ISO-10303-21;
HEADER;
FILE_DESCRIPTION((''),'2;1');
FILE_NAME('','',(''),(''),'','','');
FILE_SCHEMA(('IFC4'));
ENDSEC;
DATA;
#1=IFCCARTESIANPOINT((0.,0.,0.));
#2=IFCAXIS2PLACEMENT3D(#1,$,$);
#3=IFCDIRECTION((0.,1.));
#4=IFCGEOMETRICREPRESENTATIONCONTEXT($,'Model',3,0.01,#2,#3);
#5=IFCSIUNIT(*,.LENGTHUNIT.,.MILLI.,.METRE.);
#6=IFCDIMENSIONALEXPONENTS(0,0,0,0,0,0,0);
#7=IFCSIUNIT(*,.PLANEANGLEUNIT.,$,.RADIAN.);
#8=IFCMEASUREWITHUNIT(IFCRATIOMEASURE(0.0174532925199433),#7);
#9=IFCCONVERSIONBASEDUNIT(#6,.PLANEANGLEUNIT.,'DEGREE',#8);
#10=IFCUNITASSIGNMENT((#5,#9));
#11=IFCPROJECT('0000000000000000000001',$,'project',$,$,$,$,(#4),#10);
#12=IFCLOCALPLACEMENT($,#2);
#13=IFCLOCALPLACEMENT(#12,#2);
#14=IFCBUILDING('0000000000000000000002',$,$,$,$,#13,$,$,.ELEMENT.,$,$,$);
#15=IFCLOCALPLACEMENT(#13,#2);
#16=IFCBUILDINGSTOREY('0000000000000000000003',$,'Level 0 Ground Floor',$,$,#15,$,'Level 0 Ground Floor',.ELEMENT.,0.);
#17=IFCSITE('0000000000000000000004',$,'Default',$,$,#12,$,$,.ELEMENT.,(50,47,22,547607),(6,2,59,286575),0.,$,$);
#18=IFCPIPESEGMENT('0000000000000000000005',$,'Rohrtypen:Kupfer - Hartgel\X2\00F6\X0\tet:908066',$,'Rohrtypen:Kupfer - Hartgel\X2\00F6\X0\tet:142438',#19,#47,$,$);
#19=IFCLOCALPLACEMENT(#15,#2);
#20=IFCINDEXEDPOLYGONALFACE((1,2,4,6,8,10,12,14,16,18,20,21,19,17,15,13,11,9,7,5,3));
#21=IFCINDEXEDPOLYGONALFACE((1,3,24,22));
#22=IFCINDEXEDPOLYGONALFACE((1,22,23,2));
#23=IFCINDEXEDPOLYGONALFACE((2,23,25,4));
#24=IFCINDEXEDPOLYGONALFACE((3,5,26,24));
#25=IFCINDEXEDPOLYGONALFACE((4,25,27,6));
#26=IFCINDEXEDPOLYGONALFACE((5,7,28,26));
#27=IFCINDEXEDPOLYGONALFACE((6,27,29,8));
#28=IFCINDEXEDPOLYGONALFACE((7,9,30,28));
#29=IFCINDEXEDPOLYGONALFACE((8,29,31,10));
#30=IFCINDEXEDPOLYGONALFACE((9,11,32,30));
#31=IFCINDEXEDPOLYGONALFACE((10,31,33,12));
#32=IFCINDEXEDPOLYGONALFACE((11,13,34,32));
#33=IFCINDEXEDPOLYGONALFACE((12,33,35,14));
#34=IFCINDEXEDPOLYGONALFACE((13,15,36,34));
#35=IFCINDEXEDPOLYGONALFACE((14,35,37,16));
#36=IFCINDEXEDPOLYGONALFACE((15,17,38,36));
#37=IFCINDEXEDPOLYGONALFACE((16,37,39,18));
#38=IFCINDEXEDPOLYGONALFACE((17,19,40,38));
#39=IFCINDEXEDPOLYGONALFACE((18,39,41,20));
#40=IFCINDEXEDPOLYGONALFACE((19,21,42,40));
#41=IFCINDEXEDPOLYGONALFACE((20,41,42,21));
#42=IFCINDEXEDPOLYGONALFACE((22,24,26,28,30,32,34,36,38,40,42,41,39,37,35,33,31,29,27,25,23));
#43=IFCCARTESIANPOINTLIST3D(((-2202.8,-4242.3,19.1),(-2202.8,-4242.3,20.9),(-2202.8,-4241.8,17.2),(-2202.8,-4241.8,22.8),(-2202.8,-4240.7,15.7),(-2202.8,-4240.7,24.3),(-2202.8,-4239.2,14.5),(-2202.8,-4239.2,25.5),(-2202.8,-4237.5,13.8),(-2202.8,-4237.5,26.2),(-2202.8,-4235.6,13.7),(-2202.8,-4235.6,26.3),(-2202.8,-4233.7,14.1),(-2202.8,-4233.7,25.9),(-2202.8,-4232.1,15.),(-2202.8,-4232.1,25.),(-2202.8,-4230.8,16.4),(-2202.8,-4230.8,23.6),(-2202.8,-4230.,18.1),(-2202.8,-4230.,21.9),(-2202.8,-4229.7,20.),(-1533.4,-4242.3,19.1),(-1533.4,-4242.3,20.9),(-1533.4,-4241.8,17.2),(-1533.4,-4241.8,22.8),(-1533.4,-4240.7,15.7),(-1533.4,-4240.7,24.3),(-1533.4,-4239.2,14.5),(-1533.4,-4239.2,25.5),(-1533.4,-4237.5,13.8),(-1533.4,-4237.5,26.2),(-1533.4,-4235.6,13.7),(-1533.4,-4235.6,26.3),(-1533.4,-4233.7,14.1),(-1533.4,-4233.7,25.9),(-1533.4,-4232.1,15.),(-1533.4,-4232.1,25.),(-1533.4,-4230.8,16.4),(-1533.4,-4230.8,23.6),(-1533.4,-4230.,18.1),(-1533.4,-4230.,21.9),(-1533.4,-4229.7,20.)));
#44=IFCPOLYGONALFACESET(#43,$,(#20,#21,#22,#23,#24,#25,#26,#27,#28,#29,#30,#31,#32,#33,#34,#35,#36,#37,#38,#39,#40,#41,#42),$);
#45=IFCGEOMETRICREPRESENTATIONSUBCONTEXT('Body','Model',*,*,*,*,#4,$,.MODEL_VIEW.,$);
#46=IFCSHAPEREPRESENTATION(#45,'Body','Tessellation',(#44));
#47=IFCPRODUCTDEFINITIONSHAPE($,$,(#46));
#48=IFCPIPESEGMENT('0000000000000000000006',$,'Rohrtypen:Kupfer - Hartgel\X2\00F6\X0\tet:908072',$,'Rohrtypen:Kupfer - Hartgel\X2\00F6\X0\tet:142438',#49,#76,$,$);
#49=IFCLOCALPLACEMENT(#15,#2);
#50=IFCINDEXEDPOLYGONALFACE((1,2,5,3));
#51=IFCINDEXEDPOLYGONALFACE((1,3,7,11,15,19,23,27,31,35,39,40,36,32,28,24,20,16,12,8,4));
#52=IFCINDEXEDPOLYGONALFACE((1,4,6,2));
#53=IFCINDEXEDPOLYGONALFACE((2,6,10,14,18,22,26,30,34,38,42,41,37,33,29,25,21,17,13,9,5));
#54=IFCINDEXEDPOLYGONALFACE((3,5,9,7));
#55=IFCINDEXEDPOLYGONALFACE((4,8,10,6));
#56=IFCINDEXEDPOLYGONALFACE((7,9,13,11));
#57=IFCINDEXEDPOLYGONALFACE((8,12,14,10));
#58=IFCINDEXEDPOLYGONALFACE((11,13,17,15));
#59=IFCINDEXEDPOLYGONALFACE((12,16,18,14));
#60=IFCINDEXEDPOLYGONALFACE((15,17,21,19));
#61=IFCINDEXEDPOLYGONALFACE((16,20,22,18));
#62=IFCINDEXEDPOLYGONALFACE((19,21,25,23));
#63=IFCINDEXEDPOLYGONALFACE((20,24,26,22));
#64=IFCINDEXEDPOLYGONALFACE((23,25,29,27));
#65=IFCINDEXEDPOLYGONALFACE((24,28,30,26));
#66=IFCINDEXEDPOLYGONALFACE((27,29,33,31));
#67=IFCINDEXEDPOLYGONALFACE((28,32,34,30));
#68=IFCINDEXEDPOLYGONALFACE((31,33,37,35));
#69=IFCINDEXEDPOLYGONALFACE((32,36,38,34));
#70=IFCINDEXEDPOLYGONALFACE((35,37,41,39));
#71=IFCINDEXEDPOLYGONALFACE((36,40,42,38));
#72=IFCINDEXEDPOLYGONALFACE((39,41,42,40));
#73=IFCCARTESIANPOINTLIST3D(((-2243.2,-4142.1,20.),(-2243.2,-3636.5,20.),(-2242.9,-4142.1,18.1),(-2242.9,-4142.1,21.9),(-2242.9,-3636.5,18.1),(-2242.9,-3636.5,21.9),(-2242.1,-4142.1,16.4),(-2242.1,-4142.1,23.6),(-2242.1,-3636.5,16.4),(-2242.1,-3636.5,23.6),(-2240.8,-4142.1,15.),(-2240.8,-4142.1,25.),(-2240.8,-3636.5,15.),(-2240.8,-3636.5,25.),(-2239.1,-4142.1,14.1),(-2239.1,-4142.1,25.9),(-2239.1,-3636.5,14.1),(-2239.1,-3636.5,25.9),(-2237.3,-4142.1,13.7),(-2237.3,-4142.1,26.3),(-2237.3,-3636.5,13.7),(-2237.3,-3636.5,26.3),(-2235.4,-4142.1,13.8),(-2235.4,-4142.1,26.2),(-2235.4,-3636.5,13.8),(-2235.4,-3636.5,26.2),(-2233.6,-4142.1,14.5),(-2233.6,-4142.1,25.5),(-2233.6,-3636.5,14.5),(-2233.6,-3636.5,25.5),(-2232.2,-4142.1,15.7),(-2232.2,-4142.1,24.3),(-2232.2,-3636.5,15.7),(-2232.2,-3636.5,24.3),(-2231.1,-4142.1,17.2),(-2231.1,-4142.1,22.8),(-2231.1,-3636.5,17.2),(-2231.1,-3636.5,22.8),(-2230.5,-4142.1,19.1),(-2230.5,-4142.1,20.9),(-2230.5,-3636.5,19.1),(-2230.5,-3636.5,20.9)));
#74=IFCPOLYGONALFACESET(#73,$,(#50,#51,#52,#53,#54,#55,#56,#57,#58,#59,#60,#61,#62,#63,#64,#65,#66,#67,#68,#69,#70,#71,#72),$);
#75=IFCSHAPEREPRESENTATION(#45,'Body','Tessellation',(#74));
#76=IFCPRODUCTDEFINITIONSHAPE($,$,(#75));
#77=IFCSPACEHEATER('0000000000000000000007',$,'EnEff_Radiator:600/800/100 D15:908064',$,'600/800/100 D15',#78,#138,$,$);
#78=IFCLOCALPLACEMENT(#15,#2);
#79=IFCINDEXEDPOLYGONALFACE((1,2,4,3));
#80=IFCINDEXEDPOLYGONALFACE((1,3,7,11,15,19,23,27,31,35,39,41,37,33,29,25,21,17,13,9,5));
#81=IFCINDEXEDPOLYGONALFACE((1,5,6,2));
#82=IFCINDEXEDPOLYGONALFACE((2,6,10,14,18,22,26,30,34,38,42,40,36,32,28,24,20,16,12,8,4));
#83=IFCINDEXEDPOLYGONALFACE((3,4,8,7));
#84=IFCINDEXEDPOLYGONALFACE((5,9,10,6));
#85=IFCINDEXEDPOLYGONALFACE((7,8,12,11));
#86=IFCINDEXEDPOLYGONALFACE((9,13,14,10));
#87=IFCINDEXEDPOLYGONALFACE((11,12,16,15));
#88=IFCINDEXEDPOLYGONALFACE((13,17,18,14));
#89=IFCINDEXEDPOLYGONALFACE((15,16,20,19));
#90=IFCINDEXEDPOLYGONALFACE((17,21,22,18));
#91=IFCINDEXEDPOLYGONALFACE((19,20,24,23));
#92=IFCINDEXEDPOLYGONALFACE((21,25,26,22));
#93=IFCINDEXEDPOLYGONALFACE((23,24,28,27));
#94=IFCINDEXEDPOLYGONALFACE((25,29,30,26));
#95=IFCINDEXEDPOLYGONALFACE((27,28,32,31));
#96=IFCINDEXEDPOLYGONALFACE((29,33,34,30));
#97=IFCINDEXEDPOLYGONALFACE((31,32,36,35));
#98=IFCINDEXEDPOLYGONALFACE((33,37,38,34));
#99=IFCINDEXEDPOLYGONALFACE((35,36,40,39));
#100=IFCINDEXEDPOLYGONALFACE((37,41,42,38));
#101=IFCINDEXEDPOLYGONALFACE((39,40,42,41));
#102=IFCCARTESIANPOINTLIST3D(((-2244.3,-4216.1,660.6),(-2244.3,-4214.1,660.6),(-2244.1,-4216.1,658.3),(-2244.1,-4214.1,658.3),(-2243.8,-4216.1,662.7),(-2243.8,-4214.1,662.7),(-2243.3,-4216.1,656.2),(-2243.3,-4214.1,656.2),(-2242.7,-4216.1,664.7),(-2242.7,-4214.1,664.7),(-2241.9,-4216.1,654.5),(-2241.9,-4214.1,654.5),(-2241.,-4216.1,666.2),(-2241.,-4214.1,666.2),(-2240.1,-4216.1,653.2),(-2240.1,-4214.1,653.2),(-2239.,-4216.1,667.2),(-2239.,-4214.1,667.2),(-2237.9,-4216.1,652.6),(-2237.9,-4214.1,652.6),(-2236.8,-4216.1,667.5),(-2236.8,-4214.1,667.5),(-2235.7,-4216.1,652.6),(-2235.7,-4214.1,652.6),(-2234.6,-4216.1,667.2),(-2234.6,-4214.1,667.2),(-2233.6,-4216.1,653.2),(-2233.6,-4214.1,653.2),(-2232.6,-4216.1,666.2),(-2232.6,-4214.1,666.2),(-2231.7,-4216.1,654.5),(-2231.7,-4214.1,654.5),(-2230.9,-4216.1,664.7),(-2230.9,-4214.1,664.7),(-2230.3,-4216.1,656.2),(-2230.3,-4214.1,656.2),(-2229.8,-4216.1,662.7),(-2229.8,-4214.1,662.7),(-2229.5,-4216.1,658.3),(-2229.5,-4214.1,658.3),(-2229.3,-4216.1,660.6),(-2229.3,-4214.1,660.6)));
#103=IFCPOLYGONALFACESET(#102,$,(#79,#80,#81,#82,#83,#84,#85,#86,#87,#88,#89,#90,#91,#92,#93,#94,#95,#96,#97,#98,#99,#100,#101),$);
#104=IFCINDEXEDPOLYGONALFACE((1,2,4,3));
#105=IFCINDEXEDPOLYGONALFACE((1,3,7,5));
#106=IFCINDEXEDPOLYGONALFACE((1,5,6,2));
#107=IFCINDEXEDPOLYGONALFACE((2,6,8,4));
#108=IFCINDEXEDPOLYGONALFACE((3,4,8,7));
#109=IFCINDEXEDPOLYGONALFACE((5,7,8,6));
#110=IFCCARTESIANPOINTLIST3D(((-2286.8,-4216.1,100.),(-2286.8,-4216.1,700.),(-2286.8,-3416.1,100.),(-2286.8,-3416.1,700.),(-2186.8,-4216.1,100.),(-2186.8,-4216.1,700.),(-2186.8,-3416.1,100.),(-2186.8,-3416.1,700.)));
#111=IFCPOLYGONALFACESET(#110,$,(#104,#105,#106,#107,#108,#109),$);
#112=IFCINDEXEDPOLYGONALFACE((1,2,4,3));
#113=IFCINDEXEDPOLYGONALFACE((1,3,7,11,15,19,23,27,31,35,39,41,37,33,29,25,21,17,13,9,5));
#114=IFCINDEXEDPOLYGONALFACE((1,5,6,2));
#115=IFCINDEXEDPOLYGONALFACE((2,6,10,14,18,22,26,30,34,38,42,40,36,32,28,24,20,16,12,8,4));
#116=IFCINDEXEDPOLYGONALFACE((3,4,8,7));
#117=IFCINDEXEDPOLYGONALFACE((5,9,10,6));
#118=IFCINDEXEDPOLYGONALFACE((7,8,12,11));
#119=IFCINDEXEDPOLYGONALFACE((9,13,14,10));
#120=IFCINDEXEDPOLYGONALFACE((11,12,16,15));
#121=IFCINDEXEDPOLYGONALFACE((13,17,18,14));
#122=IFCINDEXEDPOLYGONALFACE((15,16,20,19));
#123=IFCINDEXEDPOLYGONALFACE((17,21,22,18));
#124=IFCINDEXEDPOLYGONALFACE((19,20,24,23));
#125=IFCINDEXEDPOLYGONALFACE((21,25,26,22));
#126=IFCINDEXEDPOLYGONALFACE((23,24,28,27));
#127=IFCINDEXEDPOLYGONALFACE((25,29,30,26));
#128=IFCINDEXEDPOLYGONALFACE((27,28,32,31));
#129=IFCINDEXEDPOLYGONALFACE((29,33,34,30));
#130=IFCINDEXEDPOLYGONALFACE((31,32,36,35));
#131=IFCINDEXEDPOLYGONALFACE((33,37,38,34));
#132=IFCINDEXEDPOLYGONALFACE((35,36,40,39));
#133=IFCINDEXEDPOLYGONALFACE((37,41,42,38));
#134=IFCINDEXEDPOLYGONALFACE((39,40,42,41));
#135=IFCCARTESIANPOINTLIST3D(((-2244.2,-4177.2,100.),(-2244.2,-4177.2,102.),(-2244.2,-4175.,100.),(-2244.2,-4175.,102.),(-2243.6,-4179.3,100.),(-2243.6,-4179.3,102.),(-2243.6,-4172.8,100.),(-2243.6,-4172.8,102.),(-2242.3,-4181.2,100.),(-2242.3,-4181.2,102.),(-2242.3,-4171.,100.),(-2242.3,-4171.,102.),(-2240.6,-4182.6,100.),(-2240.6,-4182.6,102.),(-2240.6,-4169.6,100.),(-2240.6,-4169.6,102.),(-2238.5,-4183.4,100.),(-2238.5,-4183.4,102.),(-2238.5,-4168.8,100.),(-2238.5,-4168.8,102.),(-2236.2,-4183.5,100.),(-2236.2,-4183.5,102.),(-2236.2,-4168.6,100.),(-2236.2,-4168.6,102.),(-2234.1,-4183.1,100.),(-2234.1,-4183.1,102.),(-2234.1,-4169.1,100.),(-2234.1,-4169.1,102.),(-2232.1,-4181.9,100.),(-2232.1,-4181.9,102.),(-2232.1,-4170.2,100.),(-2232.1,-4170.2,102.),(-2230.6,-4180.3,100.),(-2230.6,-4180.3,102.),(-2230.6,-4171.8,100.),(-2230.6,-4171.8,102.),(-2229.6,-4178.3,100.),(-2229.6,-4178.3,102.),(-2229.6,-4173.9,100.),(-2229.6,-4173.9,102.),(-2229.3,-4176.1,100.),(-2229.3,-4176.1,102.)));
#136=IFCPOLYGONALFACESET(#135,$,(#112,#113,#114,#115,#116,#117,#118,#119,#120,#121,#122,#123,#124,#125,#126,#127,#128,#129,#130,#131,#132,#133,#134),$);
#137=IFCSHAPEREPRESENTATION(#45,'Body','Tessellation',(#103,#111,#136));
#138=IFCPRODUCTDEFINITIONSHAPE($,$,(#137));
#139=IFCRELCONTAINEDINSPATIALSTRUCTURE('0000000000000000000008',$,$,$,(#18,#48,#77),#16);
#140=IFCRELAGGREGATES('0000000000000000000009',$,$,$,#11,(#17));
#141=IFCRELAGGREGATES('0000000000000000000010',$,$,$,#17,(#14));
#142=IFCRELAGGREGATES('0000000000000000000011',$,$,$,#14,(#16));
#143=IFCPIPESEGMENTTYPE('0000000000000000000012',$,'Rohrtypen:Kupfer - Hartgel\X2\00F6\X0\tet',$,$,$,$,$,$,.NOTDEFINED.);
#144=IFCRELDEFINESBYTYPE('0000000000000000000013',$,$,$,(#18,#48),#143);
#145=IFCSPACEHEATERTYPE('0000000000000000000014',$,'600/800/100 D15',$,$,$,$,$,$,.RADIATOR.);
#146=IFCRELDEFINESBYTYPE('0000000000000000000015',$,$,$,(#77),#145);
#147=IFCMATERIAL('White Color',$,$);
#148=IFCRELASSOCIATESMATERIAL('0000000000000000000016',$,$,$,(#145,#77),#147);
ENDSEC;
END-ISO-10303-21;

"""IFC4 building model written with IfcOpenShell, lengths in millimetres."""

from ifc_helpers import new_model, entity, si_unit, converted_unit, direction, frame, frame_2d, origin, place, context, subcontext, project, spatial, rectangle, circle, extrude, source, transform, mapped, material, type_object, type_shapes, element, save


model = new_model("IFC4")

# Units and contexts
model_context = context("Model", 3, precision=0.01, world=origin(), true_north=direction((0.0, 1.0)))
body_context = subcontext(model_context, "Body", "Model", "MODEL_VIEW")
ifc_project = project(units=[si_unit("LENGTHUNIT", "METRE", prefix="MILLI"), converted_unit("PLANEANGLEUNIT", "DEGREE", entity("IfcRatioMeasure", 0.0174532925199433), si_unit("PLANEANGLEUNIT", "RADIAN"), dimensions=[0, 0, 0, 0, 0, 0, 0])], contexts=[model_context])

# Site, building, storey
site_placement = place(None, origin())
site = spatial("IfcSite", under=ifc_project, at=site_placement, Name="Default", CompositionType="ELEMENT", RefLatitude=(50, 47, 22, 547607), RefLongitude=(6, 2, 59, 286575), RefElevation=0.0)
building_placement = place(site_placement, origin())
building = spatial("IfcBuilding", under=site, at=building_placement, CompositionType="ELEMENT")
storey_placement = place(building_placement, origin())
storey = spatial("IfcBuildingStorey", under=building, at=storey_placement, Name="Level 0 Ground Floor", LongName="Level 0 Ground Floor", CompositionType="ELEMENT", Elevation=0.0)

# Pipe segments
pipe_segment_type = type_object("IfcPipeSegmentType", Name="Rohrtypen:Kupfer - Hartgelötet", PredefinedType="NOTDEFINED")
pipe_segment_1_placement = place(storey_placement, frame((-2202.8, -4244.0, 12.1)))
element("IfcPipeSegment", 1, at=pipe_segment_1_placement, inside=storey, type_object=pipe_segment_type, Name="Rohrtypen:Kupfer - Hartgelötet:908066", ObjectType="Rohrtypen:Kupfer - Hartgelötet:142438", context=body_context, shape_type="SweptSolid", body=[
    extrude(circle(Radius=6.3, at=frame_2d((0.0, 0.0), x_axis=(1.0, 0.0))), frame((0.0, 7.9, 7.9), z_axis=(1.0, 0.000044, 0.0), x_axis=(-0.000044, 1.0, 0.0)), (0.0, 0.0, 1.0), 669.4),
])
pipe_segment_2_placement = place(storey_placement, frame((-2244.8, -4142.1, 12.1)))
element("IfcPipeSegment", 2, at=pipe_segment_2_placement, inside=storey, type_object=pipe_segment_type, Name="Rohrtypen:Kupfer - Hartgelötet:908072", ObjectType="Rohrtypen:Kupfer - Hartgelötet:142438", context=body_context, shape_type="SweptSolid", body=[
    extrude(circle(Radius=6.3, at=frame_2d((0.0, 0.0), x_axis=(1.0, 0.0))), frame((7.9, 0.0, 7.9), z_axis=(0.0, 1.0, 0.0), x_axis=(-1.0, 0.0, 0.0)), (0.0, 0.0, 1.0), 505.5),
])

# Space heater
ifc_material = material(Name="White Color")
space_heater_type = type_object("IfcSpaceHeaterType", Name="600/800/100 D15", PredefinedType="RADIATOR", material=ifc_material)
shared_shape_1 = source(origin(), body_context, "Body", "SweptSolid", [
    extrude(circle(Radius=7.5, at=frame_2d((0.0, 0.0), x_axis=(1.0, 0.0))), frame((798.0, 50.0, 560.0), z_axis=(1.0, 0.0, 0.0), x_axis=(0.0, 0.0, 1.0)), (0.0, 0.0, 1.0), 2.0),
    extrude(rectangle(XDim=100.0, YDim=800.0, at=frame_2d((0.0, 0.0), x_axis=(1.0, 0.0))), frame((400.0, 50.0, 0.0), z_axis=(0.0, 0.0, 1.0), x_axis=(0.0, 1.0, 0.0)), (0.0, 0.0, 1.0), 600.0),
    extrude(circle(Radius=7.5, at=frame_2d((0.0, 0.0), x_axis=(1.0, 0.0))), frame((760.0, 50.0, 0.0), z_axis=(0.0, 0.0, 1.0), x_axis=(0.0, 1.0, 0.0)), (0.0, 0.0, 1.0), 2.0),
])
type_shapes(space_heater_type, [shared_shape_1])
space_heater_placement = place(storey_placement, frame((-2286.8, -3416.1, 100.0), z_axis=(0.0, 0.0, 1.0), x_axis=(0.000017, -1.0, 0.0)))
element("IfcSpaceHeater", 3, at=space_heater_placement, inside=storey, type_object=space_heater_type, material=ifc_material, Name="EnEff_Radiator:600/800/100 D15:908064", ObjectType="600/800/100 D15", context=body_context, shape_type="MappedRepresentation", body=[
    mapped(shared_shape_1, transform((0.0, 0.0, 0.0), scale=1.0)),
])

save(model, "model.ifc")
